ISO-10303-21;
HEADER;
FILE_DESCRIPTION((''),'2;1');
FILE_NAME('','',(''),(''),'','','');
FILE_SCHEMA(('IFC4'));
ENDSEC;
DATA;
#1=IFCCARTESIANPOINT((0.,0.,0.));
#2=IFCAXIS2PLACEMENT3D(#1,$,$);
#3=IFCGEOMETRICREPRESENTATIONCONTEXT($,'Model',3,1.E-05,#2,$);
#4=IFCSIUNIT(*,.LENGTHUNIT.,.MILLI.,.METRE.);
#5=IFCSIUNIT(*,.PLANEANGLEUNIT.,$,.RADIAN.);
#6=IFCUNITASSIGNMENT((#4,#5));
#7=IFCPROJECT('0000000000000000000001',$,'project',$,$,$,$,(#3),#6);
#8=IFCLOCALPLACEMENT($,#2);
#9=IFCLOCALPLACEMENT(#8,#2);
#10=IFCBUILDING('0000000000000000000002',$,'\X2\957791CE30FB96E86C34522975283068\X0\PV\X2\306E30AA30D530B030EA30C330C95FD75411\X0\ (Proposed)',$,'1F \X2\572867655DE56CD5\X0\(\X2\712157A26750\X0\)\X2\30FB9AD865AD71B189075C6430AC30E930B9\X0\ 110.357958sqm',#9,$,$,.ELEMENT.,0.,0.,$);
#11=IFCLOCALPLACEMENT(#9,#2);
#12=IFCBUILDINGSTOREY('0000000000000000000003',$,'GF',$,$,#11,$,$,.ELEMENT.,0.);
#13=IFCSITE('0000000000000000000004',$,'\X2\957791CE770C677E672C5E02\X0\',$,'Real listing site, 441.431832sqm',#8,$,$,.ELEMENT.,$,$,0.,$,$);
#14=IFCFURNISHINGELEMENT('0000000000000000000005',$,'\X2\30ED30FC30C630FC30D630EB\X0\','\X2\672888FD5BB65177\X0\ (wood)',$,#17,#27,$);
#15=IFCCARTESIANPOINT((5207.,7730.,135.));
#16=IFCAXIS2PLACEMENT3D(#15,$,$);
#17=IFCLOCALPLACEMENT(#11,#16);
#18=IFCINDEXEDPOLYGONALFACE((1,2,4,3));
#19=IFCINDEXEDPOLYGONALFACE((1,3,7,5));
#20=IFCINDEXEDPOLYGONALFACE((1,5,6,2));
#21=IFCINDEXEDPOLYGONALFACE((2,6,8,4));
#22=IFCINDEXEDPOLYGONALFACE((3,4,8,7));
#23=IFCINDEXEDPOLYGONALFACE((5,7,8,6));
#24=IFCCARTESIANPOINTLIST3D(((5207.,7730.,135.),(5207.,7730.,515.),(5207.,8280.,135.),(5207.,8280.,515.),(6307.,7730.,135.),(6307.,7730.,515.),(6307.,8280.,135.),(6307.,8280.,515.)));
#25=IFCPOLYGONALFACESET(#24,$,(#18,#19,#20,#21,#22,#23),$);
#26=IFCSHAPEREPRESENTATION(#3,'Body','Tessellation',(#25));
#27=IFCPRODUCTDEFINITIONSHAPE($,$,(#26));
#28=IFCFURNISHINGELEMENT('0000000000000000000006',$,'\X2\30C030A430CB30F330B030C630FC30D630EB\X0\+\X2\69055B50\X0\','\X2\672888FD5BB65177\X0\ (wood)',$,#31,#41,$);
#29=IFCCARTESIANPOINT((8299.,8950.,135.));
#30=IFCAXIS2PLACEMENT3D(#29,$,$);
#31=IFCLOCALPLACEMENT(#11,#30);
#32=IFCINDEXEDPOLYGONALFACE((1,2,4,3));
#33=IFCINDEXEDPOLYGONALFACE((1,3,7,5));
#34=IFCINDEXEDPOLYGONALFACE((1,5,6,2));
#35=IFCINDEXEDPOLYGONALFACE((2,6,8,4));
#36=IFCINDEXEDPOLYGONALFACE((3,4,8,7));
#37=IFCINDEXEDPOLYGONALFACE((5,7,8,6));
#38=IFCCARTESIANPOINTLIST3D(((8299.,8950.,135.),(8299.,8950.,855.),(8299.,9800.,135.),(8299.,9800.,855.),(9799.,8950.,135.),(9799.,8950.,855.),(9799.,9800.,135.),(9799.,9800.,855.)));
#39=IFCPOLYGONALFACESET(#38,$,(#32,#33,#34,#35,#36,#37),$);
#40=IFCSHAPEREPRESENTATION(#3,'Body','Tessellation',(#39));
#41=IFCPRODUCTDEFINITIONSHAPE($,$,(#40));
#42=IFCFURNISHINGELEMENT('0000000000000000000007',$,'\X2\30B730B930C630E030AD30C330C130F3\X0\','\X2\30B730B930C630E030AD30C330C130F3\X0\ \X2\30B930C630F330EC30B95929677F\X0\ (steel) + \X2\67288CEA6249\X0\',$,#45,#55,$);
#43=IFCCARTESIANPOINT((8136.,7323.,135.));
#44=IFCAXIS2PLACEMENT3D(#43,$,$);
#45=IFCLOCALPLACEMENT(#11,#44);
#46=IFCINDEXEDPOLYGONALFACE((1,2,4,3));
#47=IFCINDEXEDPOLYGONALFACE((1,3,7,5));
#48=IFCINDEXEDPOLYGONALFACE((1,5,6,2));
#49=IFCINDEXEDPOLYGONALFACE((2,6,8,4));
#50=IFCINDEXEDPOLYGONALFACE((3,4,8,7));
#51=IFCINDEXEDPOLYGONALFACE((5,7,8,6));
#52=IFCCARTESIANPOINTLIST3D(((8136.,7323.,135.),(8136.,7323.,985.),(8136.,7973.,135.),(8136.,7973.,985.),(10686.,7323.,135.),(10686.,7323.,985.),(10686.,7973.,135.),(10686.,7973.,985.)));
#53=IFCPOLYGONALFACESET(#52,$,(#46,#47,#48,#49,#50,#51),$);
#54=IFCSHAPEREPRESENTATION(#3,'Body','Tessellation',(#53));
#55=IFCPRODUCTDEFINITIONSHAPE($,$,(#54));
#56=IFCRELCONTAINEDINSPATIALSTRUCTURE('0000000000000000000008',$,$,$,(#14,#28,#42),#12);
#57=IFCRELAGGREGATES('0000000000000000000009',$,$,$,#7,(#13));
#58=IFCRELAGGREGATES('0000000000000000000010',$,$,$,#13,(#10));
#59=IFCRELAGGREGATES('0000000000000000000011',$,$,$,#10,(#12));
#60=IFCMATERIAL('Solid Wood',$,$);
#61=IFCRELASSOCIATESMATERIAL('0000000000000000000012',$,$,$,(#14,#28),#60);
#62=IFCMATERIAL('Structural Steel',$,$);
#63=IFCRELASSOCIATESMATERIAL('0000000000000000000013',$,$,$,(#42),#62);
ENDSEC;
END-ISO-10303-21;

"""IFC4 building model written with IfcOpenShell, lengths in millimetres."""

from ifc_helpers import new_model, si_unit, frame, frame_2d, origin, place, context, project, spatial, rectangle, extrude, material, element, save


model = new_model("IFC4")

# Units and contexts
model_context = context("Model", 3, precision=1e-05, world=origin())
ifc_project = project(units=[si_unit("LENGTHUNIT", "METRE", prefix="MILLI"), si_unit("PLANEANGLEUNIT", "RADIAN")], contexts=[model_context])

# Site, building, storey
site_placement = place(None, origin())
site = spatial("IfcSite", under=ifc_project, at=site_placement, Name="長野県松本市", ObjectType="Real listing site, 441.431832sqm", CompositionType="ELEMENT", RefElevation=0.0)
building_placement = place(site_placement, origin())
building = spatial("IfcBuilding", under=site, at=building_placement, Name="長野・雨水利用とPVのオフグリッド志向 (Proposed)", ObjectType="1F 在来工法(無垢材)・高断熱複層ガラス 110.357958sqm", CompositionType="ELEMENT", ElevationOfRefHeight=0.0, ElevationOfTerrain=0.0)
storey_placement = place(building_placement, origin())
storey = spatial("IfcBuildingStorey", under=building, at=storey_placement, Name="GF", CompositionType="ELEMENT", Elevation=0.0)

# Shared definitions
ifc_material_1 = material(Name="Solid Wood")

# Shared definitions
ifc_material_2 = material(Name="Structural Steel")

# Furnishing elements
furnishing_1_placement = place(storey_placement, frame((5207.0, 7730.0, 135.0)))
element("IfcFurnishingElement", 1, at=furnishing_1_placement, inside=storey, material=ifc_material_1, Name="ローテーブル", Description="木製家具 (wood)", context=model_context, shape_type="SweptSolid", body=[
    extrude(rectangle(XDim=1100.0, YDim=550.0, at=frame_2d((550.0, 275.0))), frame((5207.0, 7730.0, 135.0)), (0.0, 0.0, 1.0), 380.0),
])
furnishing_2_placement = place(storey_placement, frame((8299.0, 8950.0, 135.0)))
element("IfcFurnishingElement", 2, at=furnishing_2_placement, inside=storey, material=ifc_material_1, Name="ダイニングテーブル+椅子", Description="木製家具 (wood)", context=model_context, shape_type="SweptSolid", body=[
    extrude(rectangle(XDim=1500.0, YDim=850.0, at=frame_2d((750.0, 425.0))), frame((8299.0, 8950.0, 135.0)), (0.0, 0.0, 1.0), 720.0),
])
furnishing_3_placement = place(storey_placement, frame((8136.0, 7323.0, 135.0)))
element("IfcFurnishingElement", 3, at=furnishing_3_placement, inside=storey, material=ifc_material_2, Name="システムキッチン", Description="システムキッチン ステンレス天板 (steel) + 木質扉", context=model_context, shape_type="SweptSolid", body=[
    extrude(rectangle(XDim=2550.0, YDim=650.0, at=frame_2d((1275.0, 325.0))), frame((8136.0, 7323.0, 135.0)), (0.0, 0.0, 1.0), 850.0),
])

save(model, "model.ifc")
